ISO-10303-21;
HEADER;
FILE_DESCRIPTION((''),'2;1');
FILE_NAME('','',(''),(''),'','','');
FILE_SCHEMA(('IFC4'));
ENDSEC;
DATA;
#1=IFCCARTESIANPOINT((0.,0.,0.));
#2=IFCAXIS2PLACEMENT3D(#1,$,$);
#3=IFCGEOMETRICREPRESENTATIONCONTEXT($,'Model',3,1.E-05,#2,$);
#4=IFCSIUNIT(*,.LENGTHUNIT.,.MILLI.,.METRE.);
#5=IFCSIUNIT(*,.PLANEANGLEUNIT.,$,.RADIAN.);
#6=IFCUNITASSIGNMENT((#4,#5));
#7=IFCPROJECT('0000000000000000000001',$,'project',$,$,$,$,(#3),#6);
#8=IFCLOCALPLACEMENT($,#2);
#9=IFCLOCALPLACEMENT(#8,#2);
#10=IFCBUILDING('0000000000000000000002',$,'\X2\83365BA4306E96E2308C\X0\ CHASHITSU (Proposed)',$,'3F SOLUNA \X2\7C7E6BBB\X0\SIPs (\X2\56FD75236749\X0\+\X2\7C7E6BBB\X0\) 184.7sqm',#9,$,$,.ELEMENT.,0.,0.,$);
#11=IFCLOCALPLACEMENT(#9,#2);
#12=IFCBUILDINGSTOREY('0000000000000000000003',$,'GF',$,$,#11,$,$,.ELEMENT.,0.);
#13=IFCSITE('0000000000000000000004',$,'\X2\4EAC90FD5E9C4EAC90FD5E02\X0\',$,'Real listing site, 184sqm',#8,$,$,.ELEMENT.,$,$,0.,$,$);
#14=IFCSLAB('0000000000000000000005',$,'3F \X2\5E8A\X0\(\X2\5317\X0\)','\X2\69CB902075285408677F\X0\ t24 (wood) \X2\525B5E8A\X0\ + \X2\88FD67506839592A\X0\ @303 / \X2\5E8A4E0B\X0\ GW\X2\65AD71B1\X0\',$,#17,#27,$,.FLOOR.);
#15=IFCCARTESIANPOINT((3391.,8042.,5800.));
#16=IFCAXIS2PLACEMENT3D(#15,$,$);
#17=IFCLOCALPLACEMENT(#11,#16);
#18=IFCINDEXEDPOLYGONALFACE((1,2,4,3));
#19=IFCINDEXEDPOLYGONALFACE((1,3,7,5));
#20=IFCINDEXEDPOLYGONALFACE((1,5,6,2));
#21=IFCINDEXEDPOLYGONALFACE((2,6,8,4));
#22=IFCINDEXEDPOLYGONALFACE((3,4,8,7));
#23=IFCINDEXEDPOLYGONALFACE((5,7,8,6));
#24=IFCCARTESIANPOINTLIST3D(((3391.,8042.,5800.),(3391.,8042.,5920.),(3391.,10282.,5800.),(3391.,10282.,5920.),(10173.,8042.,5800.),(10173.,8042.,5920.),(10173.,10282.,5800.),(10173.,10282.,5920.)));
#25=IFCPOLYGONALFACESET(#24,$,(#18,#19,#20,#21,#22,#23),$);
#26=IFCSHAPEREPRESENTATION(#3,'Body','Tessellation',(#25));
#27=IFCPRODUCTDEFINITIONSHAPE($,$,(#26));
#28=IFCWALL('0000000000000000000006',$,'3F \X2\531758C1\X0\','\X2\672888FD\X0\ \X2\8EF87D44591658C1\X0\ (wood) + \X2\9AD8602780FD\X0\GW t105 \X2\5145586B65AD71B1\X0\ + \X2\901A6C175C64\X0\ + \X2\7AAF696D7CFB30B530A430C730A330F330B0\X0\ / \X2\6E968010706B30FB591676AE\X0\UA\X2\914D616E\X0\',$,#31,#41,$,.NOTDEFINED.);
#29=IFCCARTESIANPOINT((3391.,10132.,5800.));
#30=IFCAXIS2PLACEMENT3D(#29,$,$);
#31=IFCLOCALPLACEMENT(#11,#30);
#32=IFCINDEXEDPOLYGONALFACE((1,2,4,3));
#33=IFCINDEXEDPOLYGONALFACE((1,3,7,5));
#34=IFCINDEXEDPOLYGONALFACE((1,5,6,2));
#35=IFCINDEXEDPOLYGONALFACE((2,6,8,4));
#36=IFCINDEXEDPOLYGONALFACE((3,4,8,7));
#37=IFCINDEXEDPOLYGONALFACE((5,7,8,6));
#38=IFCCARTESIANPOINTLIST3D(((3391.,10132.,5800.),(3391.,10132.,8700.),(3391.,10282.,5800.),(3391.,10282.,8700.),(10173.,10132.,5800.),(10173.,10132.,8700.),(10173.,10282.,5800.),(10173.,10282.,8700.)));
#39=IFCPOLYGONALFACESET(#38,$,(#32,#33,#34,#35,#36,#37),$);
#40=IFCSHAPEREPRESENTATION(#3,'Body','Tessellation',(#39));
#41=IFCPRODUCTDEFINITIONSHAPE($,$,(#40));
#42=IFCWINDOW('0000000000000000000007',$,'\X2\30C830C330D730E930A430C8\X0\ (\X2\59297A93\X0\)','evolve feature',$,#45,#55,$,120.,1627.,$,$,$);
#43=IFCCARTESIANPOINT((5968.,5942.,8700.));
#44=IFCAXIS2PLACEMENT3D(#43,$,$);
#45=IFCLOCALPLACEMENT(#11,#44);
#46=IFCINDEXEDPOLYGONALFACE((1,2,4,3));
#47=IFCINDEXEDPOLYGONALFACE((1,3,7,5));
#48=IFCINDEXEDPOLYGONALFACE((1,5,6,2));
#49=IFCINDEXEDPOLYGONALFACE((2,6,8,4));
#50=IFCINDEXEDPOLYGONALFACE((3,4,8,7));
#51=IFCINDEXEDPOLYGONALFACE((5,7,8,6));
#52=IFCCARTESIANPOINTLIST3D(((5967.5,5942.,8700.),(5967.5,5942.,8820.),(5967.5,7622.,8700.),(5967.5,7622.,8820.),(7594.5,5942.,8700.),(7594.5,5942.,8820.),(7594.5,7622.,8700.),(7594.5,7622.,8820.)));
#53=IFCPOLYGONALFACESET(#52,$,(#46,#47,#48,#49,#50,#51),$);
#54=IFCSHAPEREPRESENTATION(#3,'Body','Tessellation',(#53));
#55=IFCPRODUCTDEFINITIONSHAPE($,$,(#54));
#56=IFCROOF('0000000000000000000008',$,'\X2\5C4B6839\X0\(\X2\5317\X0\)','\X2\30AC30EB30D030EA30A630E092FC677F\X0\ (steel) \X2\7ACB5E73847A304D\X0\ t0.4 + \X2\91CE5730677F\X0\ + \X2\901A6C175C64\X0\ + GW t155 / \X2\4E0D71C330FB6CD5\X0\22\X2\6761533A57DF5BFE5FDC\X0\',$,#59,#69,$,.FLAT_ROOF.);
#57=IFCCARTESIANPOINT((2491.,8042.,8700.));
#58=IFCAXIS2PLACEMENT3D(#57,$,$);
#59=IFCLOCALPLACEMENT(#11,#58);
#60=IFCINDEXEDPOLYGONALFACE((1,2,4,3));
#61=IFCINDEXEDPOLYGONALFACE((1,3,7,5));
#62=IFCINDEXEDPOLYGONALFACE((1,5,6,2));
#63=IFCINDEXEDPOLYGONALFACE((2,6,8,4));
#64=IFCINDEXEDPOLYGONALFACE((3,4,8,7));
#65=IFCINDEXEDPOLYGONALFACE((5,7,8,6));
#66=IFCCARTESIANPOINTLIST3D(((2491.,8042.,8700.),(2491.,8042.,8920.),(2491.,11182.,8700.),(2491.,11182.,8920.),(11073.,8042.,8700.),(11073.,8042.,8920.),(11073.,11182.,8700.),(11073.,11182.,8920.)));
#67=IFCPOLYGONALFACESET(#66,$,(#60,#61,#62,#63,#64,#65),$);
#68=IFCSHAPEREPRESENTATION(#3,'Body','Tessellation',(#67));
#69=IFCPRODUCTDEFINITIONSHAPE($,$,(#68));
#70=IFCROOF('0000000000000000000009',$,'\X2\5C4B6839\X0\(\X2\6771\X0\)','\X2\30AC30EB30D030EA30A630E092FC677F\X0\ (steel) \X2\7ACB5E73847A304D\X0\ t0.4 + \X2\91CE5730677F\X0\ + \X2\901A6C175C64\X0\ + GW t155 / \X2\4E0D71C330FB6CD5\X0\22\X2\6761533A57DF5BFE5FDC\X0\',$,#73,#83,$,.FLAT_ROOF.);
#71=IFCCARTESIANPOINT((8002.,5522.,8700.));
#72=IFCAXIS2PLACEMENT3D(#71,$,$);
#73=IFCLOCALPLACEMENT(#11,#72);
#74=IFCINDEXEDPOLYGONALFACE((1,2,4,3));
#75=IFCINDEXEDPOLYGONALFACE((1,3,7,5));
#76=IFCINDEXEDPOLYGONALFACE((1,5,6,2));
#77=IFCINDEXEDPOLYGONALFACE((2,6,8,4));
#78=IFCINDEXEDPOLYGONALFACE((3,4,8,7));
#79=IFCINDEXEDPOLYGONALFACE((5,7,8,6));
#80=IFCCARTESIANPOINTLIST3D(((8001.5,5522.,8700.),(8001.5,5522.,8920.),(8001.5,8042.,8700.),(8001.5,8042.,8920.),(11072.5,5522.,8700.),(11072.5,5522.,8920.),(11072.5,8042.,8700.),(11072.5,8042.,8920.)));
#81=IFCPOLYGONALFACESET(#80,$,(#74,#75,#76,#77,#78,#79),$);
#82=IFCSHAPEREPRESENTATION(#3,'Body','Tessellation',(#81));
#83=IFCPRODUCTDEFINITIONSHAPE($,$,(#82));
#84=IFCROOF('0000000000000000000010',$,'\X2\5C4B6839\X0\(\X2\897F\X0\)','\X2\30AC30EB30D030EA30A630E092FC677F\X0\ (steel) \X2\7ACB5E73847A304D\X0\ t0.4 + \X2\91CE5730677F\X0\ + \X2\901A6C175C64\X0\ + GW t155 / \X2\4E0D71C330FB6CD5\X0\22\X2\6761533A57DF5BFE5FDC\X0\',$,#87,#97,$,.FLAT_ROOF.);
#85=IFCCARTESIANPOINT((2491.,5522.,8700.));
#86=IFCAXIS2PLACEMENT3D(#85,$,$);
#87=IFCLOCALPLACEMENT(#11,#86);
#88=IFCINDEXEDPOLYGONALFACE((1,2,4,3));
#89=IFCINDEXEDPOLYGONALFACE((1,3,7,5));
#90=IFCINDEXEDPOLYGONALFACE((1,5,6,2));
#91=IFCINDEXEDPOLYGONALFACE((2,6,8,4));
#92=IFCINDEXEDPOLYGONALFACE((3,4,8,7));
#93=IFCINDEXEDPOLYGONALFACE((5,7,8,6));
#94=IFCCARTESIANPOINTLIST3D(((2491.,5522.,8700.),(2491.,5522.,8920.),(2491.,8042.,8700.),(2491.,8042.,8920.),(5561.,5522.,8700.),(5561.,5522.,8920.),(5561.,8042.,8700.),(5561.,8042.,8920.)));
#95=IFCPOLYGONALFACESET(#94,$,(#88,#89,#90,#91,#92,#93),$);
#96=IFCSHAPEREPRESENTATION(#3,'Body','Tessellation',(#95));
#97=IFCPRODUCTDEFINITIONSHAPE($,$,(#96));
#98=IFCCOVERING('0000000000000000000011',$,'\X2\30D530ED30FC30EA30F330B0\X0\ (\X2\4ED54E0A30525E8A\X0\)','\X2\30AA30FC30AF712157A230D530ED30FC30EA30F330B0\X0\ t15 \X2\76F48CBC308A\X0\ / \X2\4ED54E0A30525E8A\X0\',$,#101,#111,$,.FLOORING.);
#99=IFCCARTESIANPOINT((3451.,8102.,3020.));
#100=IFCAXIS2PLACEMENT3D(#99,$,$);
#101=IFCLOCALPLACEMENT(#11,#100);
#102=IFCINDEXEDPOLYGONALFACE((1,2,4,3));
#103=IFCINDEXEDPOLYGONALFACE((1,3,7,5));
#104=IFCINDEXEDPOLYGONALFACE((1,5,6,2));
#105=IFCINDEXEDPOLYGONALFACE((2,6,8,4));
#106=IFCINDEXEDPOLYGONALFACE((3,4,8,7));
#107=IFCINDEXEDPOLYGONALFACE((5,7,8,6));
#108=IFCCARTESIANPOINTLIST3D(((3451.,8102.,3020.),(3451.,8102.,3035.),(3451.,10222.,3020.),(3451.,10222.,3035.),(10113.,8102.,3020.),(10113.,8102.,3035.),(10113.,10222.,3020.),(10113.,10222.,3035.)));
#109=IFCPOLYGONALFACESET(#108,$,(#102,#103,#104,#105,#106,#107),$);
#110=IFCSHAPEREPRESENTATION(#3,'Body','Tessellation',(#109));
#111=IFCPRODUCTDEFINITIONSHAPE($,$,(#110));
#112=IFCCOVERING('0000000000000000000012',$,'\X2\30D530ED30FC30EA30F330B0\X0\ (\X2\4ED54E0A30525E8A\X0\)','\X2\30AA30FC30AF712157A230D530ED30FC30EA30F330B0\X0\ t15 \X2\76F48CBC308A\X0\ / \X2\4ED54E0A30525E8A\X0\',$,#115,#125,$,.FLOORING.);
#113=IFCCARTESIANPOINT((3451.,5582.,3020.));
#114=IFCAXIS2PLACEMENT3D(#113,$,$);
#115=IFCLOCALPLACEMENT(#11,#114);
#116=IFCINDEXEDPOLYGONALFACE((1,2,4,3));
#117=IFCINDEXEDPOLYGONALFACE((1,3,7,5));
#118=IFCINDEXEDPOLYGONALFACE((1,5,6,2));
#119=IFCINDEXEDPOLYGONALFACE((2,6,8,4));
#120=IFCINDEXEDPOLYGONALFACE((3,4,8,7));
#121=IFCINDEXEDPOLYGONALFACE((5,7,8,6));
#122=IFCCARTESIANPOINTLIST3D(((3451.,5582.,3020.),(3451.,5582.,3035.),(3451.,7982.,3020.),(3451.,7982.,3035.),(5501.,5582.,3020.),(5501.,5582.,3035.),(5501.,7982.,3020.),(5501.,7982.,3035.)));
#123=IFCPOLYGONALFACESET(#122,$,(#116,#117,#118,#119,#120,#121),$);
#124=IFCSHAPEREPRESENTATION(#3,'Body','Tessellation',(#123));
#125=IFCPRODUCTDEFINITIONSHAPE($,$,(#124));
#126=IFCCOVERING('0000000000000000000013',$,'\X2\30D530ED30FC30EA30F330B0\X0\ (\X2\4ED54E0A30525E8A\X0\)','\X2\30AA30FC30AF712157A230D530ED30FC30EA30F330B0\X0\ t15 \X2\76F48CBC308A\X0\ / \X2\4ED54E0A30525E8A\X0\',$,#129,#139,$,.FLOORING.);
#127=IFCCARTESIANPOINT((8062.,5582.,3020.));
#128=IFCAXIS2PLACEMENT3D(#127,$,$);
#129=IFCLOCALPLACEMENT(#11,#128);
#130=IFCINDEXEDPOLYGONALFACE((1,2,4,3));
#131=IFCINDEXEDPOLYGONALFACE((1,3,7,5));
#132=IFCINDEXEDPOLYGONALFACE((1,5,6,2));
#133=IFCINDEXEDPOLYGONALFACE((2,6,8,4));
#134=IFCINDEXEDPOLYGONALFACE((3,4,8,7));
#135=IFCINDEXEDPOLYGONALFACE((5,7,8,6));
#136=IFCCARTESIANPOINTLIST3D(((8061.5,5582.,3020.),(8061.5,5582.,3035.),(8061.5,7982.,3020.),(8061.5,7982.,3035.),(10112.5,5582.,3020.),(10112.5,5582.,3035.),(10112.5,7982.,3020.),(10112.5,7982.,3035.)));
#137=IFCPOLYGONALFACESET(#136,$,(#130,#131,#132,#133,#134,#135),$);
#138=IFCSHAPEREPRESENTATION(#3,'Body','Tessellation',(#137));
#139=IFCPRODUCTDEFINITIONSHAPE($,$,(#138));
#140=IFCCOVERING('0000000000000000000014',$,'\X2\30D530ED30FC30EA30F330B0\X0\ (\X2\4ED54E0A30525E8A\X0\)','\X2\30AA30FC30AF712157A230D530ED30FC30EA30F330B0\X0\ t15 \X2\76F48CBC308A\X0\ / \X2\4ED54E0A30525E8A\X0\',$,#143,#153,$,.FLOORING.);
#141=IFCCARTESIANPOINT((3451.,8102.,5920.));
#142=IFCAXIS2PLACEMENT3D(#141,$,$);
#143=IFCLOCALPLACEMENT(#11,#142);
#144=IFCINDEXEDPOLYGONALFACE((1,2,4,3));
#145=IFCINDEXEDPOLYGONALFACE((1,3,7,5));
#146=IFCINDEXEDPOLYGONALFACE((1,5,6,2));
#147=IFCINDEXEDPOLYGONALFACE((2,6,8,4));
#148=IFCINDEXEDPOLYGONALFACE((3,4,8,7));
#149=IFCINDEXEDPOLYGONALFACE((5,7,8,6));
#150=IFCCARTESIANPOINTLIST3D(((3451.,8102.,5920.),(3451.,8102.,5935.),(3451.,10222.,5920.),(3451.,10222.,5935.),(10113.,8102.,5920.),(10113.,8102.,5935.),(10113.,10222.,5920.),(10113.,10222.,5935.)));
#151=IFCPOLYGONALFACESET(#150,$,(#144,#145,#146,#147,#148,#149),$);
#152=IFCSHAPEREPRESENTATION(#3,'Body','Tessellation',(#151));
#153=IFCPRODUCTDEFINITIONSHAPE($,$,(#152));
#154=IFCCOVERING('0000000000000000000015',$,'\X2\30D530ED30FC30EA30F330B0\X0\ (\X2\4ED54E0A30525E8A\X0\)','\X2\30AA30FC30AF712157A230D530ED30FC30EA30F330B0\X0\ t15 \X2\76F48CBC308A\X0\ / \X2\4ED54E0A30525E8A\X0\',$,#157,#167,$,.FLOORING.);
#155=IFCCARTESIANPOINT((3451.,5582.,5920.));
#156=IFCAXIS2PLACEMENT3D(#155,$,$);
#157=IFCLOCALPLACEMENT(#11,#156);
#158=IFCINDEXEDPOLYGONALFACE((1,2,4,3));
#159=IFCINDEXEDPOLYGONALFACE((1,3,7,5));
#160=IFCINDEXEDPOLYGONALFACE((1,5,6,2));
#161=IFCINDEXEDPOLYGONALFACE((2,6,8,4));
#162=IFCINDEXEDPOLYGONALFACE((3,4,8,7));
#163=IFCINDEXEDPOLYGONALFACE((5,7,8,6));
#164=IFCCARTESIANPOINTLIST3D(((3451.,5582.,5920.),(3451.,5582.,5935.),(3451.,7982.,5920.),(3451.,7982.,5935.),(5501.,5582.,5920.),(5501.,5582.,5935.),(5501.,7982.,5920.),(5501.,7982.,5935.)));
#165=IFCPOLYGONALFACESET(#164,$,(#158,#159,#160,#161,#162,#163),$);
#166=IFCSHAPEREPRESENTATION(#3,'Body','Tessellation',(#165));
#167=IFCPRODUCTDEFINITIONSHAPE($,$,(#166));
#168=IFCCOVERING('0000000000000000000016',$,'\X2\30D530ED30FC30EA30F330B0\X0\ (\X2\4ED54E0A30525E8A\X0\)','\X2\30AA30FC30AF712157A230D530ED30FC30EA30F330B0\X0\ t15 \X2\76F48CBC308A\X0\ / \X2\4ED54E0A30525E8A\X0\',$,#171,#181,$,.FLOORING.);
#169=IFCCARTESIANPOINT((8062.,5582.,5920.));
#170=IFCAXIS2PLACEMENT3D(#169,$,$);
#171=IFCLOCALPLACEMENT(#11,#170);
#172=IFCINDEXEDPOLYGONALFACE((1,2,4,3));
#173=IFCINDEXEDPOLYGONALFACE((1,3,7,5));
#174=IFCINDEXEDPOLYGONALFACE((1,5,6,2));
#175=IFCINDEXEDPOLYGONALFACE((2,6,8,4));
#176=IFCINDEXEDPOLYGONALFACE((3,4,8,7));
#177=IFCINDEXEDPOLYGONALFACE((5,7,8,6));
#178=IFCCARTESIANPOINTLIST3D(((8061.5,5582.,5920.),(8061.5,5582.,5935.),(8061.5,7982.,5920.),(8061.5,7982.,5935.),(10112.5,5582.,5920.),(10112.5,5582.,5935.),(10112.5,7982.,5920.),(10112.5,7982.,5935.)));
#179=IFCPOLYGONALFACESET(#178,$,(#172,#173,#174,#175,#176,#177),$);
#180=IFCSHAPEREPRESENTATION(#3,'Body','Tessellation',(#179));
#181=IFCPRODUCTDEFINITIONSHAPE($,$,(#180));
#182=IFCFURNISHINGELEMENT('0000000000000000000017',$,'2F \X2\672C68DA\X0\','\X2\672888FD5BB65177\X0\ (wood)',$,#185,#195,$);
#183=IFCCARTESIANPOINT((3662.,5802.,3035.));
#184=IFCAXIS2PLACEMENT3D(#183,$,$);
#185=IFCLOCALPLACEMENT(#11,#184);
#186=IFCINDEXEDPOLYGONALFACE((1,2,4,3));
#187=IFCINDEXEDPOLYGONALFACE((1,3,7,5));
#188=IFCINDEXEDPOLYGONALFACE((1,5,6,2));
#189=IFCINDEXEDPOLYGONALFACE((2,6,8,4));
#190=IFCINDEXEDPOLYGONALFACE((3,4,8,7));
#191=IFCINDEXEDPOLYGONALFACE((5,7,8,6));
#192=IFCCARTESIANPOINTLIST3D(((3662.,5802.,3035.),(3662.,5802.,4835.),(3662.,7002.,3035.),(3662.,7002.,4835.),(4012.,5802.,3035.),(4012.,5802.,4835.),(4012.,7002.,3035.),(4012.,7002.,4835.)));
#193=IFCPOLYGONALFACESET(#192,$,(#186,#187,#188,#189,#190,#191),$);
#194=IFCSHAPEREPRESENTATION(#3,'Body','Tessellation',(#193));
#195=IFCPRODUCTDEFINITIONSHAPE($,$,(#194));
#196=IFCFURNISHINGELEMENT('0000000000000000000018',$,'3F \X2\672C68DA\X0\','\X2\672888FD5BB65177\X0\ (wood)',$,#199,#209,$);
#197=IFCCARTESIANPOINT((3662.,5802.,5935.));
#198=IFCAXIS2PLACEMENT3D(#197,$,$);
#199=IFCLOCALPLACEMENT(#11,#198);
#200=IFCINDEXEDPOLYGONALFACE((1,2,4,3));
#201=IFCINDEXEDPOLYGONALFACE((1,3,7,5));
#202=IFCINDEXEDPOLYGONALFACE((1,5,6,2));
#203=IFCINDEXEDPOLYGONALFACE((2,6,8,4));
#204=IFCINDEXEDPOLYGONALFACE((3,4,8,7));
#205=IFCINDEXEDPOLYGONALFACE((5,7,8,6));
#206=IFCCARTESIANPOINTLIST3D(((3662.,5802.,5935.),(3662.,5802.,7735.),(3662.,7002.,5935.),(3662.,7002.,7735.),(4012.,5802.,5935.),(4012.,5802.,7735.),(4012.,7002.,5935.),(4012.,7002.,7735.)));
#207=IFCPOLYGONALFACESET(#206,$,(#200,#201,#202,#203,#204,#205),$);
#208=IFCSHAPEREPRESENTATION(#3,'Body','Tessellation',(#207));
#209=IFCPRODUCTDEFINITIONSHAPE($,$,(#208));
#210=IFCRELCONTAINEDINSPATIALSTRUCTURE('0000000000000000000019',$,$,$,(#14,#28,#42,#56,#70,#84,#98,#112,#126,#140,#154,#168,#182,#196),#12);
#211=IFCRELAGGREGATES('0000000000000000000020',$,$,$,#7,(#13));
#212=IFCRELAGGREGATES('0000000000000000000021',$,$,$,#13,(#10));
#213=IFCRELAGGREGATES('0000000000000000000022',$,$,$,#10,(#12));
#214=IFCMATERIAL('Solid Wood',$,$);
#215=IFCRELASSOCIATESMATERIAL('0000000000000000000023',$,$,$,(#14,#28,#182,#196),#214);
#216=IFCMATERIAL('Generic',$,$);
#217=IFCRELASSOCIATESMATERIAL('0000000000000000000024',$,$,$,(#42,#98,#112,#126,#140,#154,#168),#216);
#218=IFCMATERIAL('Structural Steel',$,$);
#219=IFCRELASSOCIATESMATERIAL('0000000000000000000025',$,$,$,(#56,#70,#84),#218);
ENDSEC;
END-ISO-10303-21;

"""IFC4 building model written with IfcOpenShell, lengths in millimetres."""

from ifc_helpers import new_model, si_unit, frame, frame_2d, origin, place, context, project, spatial, rectangle, extrude, material, element, save


model = new_model("IFC4")

# Units and contexts
model_context = context("Model", 3, precision=1e-05, world=origin())
ifc_project = project(units=[si_unit("LENGTHUNIT", "METRE", prefix="MILLI"), si_unit("PLANEANGLEUNIT", "RADIAN")], contexts=[model_context])

# Site, building, storey
site_placement = place(None, origin())
site = spatial("IfcSite", under=ifc_project, at=site_placement, Name="京都府京都市", ObjectType="Real listing site, 184sqm", CompositionType="ELEMENT", RefElevation=0.0)
building_placement = place(site_placement, origin())
building = spatial("IfcBuilding", under=site, at=building_placement, Name="茶室の離れ CHASHITSU (Proposed)", ObjectType="3F SOLUNA 籾殻SIPs (国産杉+籾殻) 184.7sqm", CompositionType="ELEMENT", ElevationOfRefHeight=0.0, ElevationOfTerrain=0.0)
storey_placement = place(building_placement, origin())
storey = spatial("IfcBuildingStorey", under=building, at=storey_placement, Name="GF", CompositionType="ELEMENT", Elevation=0.0)

# Slab
ifc_material_1 = material(Name="Solid Wood")
slab_placement = place(storey_placement, frame((3391.0, 8042.0, 5800.0)))
element("IfcSlab", 1, at=slab_placement, inside=storey, material=ifc_material_1, Name="3F 床(北)", Description="構造用合板 t24 (wood) 剛床 + 製材根太 @303 / 床下 GW断熱", PredefinedType="FLOOR", context=model_context, shape_type="SweptSolid", body=[
    extrude(rectangle(XDim=6782.0, YDim=2240.0, at=frame_2d((3391.0, 1120.0))), frame((3391.0, 8042.0, 5800.0)), (0.0, 0.0, 1.0), 120.0),
])

# Wall
wall_1_placement = place(storey_placement, frame((3391.0, 10132.0, 5800.0)))
element("IfcWall", 2, at=wall_1_placement, inside=storey, material=ifc_material_1, Name="3F 北壁", Description="木製 軸組外壁 (wood) + 高性能GW t105 充填断熱 + 通気層 + 窯業系サイディング / 準耐火・外皮UA配慮", PredefinedType="NOTDEFINED", context=model_context, shape_type="SweptSolid", body=[
    extrude(rectangle(XDim=6782.0, YDim=150.0, at=frame_2d((3391.0, 75.0))), frame((3391.0, 10132.0, 5800.0)), (0.0, 0.0, 1.0), 2900.0),
])

# Window
ifc_material_2 = material(Name="Generic")
window_1_placement = place(storey_placement, frame((5968.0, 5942.0, 8700.0)))
element("IfcWindow", 3, at=window_1_placement, inside=storey, material=ifc_material_2, Name="トップライト (天窓)", Description="evolve feature", OverallHeight=120.0, OverallWidth=1627.0, context=model_context, shape_type="SweptSolid", body=[
    extrude(rectangle(XDim=1627.0, YDim=1680.0, at=frame_2d((813.0, 840.0))), frame((5968.0, 5942.0, 8700.0)), (0.0, 0.0, 1.0), 120.0),
])

# Roofs
ifc_material_3 = material(Name="Structural Steel")
roof_1_placement = place(storey_placement, frame((2491.0, 8042.0, 8700.0)))
element("IfcRoof", 4, at=roof_1_placement, inside=storey, material=ifc_material_3, Name="屋根(北)", Description="ガルバリウム鋼板 (steel) 立平葺き t0.4 + 野地板 + 通気層 + GW t155 / 不燃・法22条区域対応", PredefinedType="FLAT_ROOF", context=model_context, shape_type="SweptSolid", body=[
    extrude(rectangle(XDim=8582.0, YDim=3140.0, at=frame_2d((4291.0, 1570.0))), frame((2491.0, 8042.0, 8700.0)), (0.0, 0.0, 1.0), 220.0),
])
roof_2_placement = place(storey_placement, frame((8002.0, 5522.0, 8700.0)))
element("IfcRoof", 5, at=roof_2_placement, inside=storey, material=ifc_material_3, Name="屋根(東)", Description="ガルバリウム鋼板 (steel) 立平葺き t0.4 + 野地板 + 通気層 + GW t155 / 不燃・法22条区域対応", PredefinedType="FLAT_ROOF", context=model_context, shape_type="SweptSolid", body=[
    extrude(rectangle(XDim=3071.0, YDim=2520.0, at=frame_2d((1535.0, 1260.0))), frame((8002.0, 5522.0, 8700.0)), (0.0, 0.0, 1.0), 220.0),
])
roof_3_placement = place(storey_placement, frame((2491.0, 5522.0, 8700.0)))
element("IfcRoof", 6, at=roof_3_placement, inside=storey, material=ifc_material_3, Name="屋根(西)", Description="ガルバリウム鋼板 (steel) 立平葺き t0.4 + 野地板 + 通気層 + GW t155 / 不燃・法22条区域対応", PredefinedType="FLAT_ROOF", context=model_context, shape_type="SweptSolid", body=[
    extrude(rectangle(XDim=3070.0, YDim=2520.0, at=frame_2d((1535.0, 1260.0))), frame((2491.0, 5522.0, 8700.0)), (0.0, 0.0, 1.0), 220.0),
])

# Coverings
covering_1_placement = place(storey_placement, frame((3451.0, 8102.0, 3020.0)))
element("IfcCovering", 7, at=covering_1_placement, inside=storey, material=ifc_material_2, Name="フローリング (仕上げ床)", Description="オーク無垢フローリング t15 直貼り / 仕上げ床", PredefinedType="FLOORING", context=model_context, shape_type="SweptSolid", body=[
    extrude(rectangle(XDim=6662.0, YDim=2120.0, at=frame_2d((3331.0, 1060.0))), frame((3451.0, 8102.0, 3020.0)), (0.0, 0.0, 1.0), 15.0),
])
covering_2_placement = place(storey_placement, frame((3451.0, 5582.0, 3020.0)))
element("IfcCovering", 8, at=covering_2_placement, inside=storey, material=ifc_material_2, Name="フローリング (仕上げ床)", Description="オーク無垢フローリング t15 直貼り / 仕上げ床", PredefinedType="FLOORING", context=model_context, shape_type="SweptSolid", body=[
    extrude(rectangle(XDim=2050.0, YDim=2400.0, at=frame_2d((1025.0, 1200.0))), frame((3451.0, 5582.0, 3020.0)), (0.0, 0.0, 1.0), 15.0),
])
covering_3_placement = place(storey_placement, frame((8062.0, 5582.0, 3020.0)))
element("IfcCovering", 9, at=covering_3_placement, inside=storey, material=ifc_material_2, Name="フローリング (仕上げ床)", Description="オーク無垢フローリング t15 直貼り / 仕上げ床", PredefinedType="FLOORING", context=model_context, shape_type="SweptSolid", body=[
    extrude(rectangle(XDim=2051.0, YDim=2400.0, at=frame_2d((1025.0, 1200.0))), frame((8062.0, 5582.0, 3020.0)), (0.0, 0.0, 1.0), 15.0),
])
covering_4_placement = place(storey_placement, frame((3451.0, 8102.0, 5920.0)))
element("IfcCovering", 10, at=covering_4_placement, inside=storey, material=ifc_material_2, Name="フローリング (仕上げ床)", Description="オーク無垢フローリング t15 直貼り / 仕上げ床", PredefinedType="FLOORING", context=model_context, shape_type="SweptSolid", body=[
    extrude(rectangle(XDim=6662.0, YDim=2120.0, at=frame_2d((3331.0, 1060.0))), frame((3451.0, 8102.0, 5920.0)), (0.0, 0.0, 1.0), 15.0),
])
covering_5_placement = place(storey_placement, frame((3451.0, 5582.0, 5920.0)))
element("IfcCovering", 11, at=covering_5_placement, inside=storey, material=ifc_material_2, Name="フローリング (仕上げ床)", Description="オーク無垢フローリング t15 直貼り / 仕上げ床", PredefinedType="FLOORING", context=model_context, shape_type="SweptSolid", body=[
    extrude(rectangle(XDim=2050.0, YDim=2400.0, at=frame_2d((1025.0, 1200.0))), frame((3451.0, 5582.0, 5920.0)), (0.0, 0.0, 1.0), 15.0),
])
covering_6_placement = place(storey_placement, frame((8062.0, 5582.0, 5920.0)))
element("IfcCovering", 12, at=covering_6_placement, inside=storey, material=ifc_material_2, Name="フローリング (仕上げ床)", Description="オーク無垢フローリング t15 直貼り / 仕上げ床", PredefinedType="FLOORING", context=model_context, shape_type="SweptSolid", body=[
    extrude(rectangle(XDim=2051.0, YDim=2400.0, at=frame_2d((1025.0, 1200.0))), frame((8062.0, 5582.0, 5920.0)), (0.0, 0.0, 1.0), 15.0),
])

# Furnishing elements
furnishing_1_placement = place(storey_placement, frame((3662.0, 5802.0, 3035.0)))
element("IfcFurnishingElement", 13, at=furnishing_1_placement, inside=storey, material=ifc_material_1, Name="2F 本棚", Description="木製家具 (wood)", context=model_context, shape_type="SweptSolid", body=[
    extrude(rectangle(XDim=350.0, YDim=1200.0, at=frame_2d((175.0, 600.0))), frame((3662.0, 5802.0, 3035.0)), (0.0, 0.0, 1.0), 1800.0),
])
furnishing_2_placement = place(storey_placement, frame((3662.0, 5802.0, 5935.0)))
element("IfcFurnishingElement", 14, at=furnishing_2_placement, inside=storey, material=ifc_material_1, Name="3F 本棚", Description="木製家具 (wood)", context=model_context, shape_type="SweptSolid", body=[
    extrude(rectangle(XDim=350.0, YDim=1200.0, at=frame_2d((175.0, 600.0))), frame((3662.0, 5802.0, 5935.0)), (0.0, 0.0, 1.0), 1800.0),
])

save(model, "model.ifc")
